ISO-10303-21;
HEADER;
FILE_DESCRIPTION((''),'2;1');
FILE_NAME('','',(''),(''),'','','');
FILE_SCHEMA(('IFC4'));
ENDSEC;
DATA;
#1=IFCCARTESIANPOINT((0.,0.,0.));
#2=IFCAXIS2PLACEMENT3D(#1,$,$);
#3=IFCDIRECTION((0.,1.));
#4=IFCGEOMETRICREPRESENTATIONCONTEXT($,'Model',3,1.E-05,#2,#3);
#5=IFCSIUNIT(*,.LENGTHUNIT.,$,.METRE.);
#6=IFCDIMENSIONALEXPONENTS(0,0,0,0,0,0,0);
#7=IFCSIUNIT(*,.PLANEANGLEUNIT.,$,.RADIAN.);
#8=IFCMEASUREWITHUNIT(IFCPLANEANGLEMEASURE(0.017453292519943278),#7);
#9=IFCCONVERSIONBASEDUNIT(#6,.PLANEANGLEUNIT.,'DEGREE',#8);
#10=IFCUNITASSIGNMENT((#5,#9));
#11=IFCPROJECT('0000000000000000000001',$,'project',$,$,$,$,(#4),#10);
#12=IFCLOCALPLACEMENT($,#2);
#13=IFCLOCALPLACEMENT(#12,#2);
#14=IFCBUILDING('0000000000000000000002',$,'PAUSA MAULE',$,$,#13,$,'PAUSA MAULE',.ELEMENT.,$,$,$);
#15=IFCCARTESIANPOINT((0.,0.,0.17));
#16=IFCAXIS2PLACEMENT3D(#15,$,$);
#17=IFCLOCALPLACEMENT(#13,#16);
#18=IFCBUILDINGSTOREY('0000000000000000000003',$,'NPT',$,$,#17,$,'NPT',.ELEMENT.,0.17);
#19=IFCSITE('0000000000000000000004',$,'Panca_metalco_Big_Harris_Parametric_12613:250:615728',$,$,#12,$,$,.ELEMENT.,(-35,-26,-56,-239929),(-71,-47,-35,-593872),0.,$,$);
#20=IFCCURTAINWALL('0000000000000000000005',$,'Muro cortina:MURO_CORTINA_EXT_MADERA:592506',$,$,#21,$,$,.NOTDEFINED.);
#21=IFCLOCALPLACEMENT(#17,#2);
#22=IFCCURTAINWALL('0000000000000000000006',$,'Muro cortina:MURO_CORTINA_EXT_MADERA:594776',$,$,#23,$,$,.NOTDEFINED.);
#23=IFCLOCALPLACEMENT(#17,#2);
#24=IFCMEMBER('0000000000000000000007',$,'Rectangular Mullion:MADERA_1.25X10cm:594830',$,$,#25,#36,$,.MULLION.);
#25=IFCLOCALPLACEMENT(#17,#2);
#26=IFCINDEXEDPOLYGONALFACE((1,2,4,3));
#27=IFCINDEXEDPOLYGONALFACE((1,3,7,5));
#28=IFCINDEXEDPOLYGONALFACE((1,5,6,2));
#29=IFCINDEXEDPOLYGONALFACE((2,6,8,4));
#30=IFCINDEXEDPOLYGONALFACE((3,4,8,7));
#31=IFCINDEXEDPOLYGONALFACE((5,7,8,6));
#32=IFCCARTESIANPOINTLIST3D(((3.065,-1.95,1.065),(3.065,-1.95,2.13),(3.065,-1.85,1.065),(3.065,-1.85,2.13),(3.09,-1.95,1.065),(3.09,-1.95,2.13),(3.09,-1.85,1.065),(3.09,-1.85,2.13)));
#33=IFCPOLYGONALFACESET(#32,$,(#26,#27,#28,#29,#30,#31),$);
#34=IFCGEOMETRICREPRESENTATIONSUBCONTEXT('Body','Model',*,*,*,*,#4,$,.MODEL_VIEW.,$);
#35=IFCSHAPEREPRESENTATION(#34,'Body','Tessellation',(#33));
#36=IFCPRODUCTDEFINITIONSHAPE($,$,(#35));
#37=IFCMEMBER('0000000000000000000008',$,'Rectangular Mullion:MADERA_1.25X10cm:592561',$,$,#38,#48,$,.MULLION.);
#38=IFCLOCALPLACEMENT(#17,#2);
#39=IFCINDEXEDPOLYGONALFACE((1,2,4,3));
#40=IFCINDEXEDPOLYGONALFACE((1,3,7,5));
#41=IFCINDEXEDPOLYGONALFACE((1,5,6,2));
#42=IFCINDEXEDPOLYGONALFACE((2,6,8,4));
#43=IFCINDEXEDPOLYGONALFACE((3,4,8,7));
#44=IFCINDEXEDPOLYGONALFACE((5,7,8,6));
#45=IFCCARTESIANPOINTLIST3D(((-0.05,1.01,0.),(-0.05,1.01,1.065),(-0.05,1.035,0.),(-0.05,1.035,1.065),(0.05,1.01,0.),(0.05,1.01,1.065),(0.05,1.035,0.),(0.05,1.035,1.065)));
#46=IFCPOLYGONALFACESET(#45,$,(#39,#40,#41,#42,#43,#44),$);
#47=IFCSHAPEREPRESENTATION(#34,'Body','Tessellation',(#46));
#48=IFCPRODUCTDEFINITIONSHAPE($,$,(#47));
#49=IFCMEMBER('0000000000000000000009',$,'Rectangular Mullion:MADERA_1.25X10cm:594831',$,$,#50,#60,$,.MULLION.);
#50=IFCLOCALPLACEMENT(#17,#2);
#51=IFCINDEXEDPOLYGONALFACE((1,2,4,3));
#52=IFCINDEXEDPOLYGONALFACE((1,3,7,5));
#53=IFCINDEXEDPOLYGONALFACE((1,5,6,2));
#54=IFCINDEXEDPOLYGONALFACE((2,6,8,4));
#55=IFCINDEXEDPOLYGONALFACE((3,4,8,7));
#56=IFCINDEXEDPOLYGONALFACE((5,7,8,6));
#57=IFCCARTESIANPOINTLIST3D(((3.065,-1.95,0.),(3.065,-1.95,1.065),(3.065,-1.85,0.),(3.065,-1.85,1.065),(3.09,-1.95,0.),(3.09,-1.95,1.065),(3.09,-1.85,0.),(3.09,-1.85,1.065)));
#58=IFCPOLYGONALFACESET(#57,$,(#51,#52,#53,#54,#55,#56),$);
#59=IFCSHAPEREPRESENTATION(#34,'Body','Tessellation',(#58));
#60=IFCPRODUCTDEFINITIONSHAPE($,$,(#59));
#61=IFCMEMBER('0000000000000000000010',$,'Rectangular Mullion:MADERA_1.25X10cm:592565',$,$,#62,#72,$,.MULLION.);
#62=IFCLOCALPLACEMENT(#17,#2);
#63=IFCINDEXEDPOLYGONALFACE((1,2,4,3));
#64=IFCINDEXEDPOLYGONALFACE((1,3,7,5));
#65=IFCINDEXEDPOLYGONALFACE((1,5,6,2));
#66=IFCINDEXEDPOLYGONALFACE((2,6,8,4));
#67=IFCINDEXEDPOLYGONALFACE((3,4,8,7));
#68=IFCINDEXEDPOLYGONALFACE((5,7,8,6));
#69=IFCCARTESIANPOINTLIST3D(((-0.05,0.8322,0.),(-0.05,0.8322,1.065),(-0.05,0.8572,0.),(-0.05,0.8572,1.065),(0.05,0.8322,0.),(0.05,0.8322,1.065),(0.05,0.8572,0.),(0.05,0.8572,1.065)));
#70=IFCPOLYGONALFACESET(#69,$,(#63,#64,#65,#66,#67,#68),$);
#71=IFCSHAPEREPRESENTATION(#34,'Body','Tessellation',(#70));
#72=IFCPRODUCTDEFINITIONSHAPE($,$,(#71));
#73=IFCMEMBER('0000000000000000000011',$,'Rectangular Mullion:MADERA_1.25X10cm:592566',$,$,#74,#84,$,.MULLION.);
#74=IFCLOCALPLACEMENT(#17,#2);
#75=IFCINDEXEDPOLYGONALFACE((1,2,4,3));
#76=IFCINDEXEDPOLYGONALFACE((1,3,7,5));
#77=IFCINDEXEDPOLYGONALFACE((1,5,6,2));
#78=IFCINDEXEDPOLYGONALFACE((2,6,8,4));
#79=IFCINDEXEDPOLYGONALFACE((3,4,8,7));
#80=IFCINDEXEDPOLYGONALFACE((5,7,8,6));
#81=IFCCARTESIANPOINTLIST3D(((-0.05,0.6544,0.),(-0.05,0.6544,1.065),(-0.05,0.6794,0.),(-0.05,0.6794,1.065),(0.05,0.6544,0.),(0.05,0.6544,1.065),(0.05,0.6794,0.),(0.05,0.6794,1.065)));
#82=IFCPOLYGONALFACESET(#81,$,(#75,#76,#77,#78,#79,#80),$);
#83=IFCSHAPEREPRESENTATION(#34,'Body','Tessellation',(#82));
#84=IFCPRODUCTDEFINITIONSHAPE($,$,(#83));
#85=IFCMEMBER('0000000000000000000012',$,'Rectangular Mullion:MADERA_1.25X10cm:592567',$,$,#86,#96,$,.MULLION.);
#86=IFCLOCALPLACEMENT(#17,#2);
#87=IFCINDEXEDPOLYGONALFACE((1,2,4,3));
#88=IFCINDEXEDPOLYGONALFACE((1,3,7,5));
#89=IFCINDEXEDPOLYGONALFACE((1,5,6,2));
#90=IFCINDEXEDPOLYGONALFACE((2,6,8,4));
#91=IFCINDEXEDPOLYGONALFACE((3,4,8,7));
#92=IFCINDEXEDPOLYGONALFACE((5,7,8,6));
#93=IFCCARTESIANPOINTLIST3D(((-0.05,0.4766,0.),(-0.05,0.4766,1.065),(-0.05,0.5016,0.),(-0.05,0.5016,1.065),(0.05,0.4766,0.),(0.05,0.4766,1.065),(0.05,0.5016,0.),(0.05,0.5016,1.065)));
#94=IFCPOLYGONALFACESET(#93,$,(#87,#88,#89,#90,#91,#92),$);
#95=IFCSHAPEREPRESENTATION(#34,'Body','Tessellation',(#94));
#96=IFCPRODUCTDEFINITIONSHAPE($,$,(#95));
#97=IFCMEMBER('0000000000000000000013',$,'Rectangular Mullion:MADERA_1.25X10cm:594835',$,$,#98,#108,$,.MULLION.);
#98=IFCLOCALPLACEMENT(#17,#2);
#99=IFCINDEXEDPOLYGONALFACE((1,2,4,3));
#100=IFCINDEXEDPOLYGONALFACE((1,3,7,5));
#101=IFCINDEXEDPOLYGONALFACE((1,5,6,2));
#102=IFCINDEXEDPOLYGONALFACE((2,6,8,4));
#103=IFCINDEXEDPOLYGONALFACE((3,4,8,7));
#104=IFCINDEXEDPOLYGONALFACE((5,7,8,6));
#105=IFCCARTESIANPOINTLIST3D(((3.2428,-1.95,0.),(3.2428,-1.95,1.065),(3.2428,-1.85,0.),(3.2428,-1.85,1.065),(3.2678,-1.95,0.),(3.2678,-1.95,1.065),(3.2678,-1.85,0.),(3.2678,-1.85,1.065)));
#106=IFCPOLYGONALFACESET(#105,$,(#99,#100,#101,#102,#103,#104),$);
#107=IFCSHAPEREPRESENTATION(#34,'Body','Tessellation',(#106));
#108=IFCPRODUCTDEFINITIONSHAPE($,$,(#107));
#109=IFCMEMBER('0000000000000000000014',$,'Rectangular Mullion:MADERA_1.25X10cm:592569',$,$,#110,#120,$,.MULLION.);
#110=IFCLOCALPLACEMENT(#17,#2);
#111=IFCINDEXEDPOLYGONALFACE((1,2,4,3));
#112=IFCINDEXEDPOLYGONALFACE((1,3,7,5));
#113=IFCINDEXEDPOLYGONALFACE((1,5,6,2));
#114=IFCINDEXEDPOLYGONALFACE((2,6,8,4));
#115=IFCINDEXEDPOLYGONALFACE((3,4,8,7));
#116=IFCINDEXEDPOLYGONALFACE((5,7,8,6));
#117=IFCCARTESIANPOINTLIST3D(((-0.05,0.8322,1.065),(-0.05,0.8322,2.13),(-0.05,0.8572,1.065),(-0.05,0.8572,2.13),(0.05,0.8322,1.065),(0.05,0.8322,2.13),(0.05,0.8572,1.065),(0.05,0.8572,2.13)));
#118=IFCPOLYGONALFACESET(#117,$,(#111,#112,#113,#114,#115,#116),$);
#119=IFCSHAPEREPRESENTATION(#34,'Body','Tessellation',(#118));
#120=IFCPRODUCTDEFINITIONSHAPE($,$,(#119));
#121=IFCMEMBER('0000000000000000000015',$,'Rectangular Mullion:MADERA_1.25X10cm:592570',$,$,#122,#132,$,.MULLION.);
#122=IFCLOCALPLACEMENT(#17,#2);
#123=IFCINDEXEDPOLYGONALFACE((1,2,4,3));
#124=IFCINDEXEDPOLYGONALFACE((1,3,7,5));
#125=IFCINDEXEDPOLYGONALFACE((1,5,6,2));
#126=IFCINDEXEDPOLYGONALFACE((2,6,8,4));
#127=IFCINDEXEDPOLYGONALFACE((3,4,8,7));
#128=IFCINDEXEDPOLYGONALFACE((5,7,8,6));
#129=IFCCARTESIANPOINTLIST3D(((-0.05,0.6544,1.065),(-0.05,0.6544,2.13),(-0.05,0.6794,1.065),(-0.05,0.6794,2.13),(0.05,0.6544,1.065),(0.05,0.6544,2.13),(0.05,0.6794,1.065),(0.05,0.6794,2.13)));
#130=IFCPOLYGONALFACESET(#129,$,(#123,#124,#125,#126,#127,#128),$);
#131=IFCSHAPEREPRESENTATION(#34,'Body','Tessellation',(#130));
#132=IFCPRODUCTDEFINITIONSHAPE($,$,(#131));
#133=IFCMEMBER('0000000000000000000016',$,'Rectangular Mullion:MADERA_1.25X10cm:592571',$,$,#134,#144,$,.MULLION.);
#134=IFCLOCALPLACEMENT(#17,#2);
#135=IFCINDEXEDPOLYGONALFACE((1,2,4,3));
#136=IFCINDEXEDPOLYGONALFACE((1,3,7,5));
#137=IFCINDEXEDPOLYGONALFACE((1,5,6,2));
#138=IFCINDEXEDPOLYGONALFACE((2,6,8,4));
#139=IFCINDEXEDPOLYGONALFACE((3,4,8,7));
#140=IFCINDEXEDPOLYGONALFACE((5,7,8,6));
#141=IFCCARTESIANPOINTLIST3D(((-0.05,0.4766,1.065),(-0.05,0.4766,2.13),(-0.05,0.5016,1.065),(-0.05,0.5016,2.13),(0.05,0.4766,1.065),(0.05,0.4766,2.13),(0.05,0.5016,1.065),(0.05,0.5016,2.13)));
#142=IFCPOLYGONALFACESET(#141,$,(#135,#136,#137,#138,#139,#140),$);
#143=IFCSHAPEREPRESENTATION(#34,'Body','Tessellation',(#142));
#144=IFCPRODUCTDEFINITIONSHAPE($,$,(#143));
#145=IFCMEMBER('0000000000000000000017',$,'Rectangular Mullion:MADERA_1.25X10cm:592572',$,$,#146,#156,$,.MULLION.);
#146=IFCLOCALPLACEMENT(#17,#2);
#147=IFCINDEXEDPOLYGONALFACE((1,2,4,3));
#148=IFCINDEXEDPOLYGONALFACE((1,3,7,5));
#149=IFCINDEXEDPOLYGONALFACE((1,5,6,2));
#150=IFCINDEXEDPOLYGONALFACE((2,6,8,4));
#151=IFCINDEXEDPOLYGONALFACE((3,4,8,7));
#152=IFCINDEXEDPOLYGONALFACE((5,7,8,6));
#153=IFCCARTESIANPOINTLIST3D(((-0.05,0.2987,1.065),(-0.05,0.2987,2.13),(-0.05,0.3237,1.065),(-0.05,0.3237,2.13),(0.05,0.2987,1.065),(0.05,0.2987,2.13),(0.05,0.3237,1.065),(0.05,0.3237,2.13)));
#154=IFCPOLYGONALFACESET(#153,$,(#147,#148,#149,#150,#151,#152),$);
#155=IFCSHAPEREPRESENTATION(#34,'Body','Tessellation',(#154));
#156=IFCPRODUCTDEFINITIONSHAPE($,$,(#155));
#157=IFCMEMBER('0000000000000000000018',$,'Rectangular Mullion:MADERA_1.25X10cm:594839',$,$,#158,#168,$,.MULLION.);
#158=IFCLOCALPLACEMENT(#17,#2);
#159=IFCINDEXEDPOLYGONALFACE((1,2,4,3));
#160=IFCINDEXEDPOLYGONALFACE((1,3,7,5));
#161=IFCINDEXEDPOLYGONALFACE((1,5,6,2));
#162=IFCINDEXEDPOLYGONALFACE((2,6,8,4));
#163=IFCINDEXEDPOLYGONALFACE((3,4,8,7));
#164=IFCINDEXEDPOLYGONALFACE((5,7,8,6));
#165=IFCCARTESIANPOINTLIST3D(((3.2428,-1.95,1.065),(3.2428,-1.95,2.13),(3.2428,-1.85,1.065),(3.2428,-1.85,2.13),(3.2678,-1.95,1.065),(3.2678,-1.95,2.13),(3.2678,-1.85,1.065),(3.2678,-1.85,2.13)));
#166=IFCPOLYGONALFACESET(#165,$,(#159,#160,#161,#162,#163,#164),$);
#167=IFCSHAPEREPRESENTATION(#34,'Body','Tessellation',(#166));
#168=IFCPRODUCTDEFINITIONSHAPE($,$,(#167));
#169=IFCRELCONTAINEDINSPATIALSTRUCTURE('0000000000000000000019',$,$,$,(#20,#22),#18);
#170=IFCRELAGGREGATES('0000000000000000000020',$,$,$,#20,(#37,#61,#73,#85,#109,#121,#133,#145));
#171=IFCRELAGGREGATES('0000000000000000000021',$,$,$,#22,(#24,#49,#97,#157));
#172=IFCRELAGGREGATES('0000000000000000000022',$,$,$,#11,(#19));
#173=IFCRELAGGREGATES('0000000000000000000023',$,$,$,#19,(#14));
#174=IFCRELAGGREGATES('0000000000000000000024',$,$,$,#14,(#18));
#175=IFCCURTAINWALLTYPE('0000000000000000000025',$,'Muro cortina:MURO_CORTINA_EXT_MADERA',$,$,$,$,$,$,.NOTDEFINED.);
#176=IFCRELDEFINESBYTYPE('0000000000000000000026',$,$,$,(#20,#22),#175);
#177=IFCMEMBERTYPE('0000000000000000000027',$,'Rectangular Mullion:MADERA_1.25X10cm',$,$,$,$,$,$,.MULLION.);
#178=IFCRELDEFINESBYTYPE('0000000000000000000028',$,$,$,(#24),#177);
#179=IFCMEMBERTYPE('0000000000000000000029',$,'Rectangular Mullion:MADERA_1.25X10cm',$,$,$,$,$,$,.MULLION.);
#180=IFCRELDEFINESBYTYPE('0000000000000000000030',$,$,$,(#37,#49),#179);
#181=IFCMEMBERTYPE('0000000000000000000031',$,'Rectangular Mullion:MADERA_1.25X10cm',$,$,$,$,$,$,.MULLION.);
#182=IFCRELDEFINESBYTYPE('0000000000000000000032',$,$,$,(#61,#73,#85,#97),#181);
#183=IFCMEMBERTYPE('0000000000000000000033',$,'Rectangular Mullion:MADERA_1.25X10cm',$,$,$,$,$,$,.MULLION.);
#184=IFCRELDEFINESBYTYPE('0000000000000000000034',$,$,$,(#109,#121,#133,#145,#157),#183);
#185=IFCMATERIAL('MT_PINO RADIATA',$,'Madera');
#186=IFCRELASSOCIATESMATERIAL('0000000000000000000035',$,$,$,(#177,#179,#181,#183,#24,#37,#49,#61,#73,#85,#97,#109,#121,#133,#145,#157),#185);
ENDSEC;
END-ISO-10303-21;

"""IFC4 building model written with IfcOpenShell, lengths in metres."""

from ifc_helpers import new_model, entity, si_unit, converted_unit, direction, frame, frame_2d, origin, place, context, subcontext, project, spatial, rectangle, extrude, source, transform, mapped, material, material_profile, profile_set, profile_usage, type_object, type_shapes, element, aggregate, save


model = new_model("IFC4")

# Units and contexts
model_context = context("Model", 3, precision=1e-05, world=origin(), true_north=direction((0.0, 1.0)))
body_context = subcontext(model_context, "Body", "Model", "MODEL_VIEW")
ifc_project = project(units=[si_unit("LENGTHUNIT", "METRE"), converted_unit("PLANEANGLEUNIT", "DEGREE", entity("IfcPlaneAngleMeasure", 0.017453292519943278), si_unit("PLANEANGLEUNIT", "RADIAN"), dimensions=[0, 0, 0, 0, 0, 0, 0])], contexts=[model_context])

# Site, building, storey
site_placement = place(None, origin())
site = spatial("IfcSite", under=ifc_project, at=site_placement, Name="Panca_metalco_Big_Harris_Parametric_12613:250:615728", CompositionType="ELEMENT", RefLatitude=(-35, -26, -56, -239929), RefLongitude=(-71, -47, -35, -593872), RefElevation=0.0)
building_placement = place(site_placement, origin())
building = spatial("IfcBuilding", under=site, at=building_placement, Name="PAUSA MAULE", LongName="PAUSA MAULE", CompositionType="ELEMENT")
storey_placement = place(building_placement, frame((0.0, 0.0, 0.17)))
storey = spatial("IfcBuildingStorey", under=building, at=storey_placement, Name="NPT", LongName="NPT", CompositionType="ELEMENT", Elevation=0.17)

# Curtain walls
curtain_wall_type = type_object("IfcCurtainWallType", Name="Muro cortina:MURO_CORTINA_EXT_MADERA", PredefinedType="NOTDEFINED")
curtain_wall_1_placement = place(storey_placement, frame((0.0, 0.0, -0.17)))
curtain_wall_1 = element("IfcCurtainWall", 1, at=curtain_wall_1_placement, inside=storey, type_object=curtain_wall_type, Name="Muro cortina:MURO_CORTINA_EXT_MADERA:592506", PredefinedType="NOTDEFINED")
ifc_material = material(Name="MT_PINO RADIATA", Category="Madera")
ifc_material_profile = material_profile(ifc_material, rectangle(XDim=0.025, YDim=0.1, at=frame_2d((0.0, 0.0), x_axis=(1.0, 0.0))), Name="MADERA_1.25X10cm")
ifc_profile_set = profile_set([ifc_material_profile], Name="MADERA_1.25X10cm")
ifc_profile_usage = profile_usage(ifc_profile_set)
curtain_wall_2_placement = place(storey_placement, frame((0.0, 0.0, -0.17)))
curtain_wall_2 = element("IfcCurtainWall", 2, at=curtain_wall_2_placement, inside=storey, type_object=curtain_wall_type, Name="Muro cortina:MURO_CORTINA_EXT_MADERA:594776", PredefinedType="NOTDEFINED")

# Members
member_type_1 = type_object("IfcMemberType", Name="Rectangular Mullion:MADERA_1.25X10cm", PredefinedType="MULLION", material=ifc_profile_set)
shared_shape_1 = source(origin(), body_context, "Body", "SweptSolid", [
    extrude(rectangle(XDim=0.025, YDim=0.1, at=frame_2d((0.0, 0.0), x_axis=(1.0, 0.0))), frame((-0.0125, 0.0, -1.065), z_axis=(0.0, 0.0, 1.0), x_axis=(-1.0, 0.0, 0.0)), (0.0, 0.0, 1.0), 1.065),
])
type_shapes(member_type_1, [shared_shape_1])
member_1_placement = place(curtain_wall_2_placement, frame((3.065, -1.9, 2.3), z_axis=(0.0, 0.0, 1.0), x_axis=(-1.0, 0.0, 0.0)))
member_1 = element("IfcMember", 3, at=member_1_placement, type_object=member_type_1, material=ifc_profile_usage, Name="Rectangular Mullion:MADERA_1.25X10cm:594830", PredefinedType="MULLION", context=body_context, shape_type="MappedRepresentation", body=[
    mapped(shared_shape_1, transform((0.0, 0.0, 0.0), scale=1.0)),
])
member_type_2 = type_object("IfcMemberType", Name="Rectangular Mullion:MADERA_1.25X10cm", PredefinedType="MULLION", material=ifc_profile_set)
shared_shape_2 = source(origin(), body_context, "Body", "SweptSolid", [
    extrude(rectangle(XDim=0.025, YDim=0.1, at=frame_2d((0.0, 0.0), x_axis=(1.0, 0.0))), frame((-0.0125, 0.0, -1.065), z_axis=(0.0, 0.0, 1.0), x_axis=(-1.0, 0.0, 0.0)), (0.0, 0.0, 1.0), 1.065),
])
type_shapes(member_type_2, [shared_shape_2])
member_2_placement = place(curtain_wall_1_placement, frame((0.0, 1.035, 1.235), z_axis=(0.0, 0.0, 1.0), x_axis=(0.0, 1.0, 0.0)))
member_2 = element("IfcMember", 4, at=member_2_placement, type_object=member_type_2, material=ifc_profile_usage, Name="Rectangular Mullion:MADERA_1.25X10cm:592561", PredefinedType="MULLION", context=body_context, shape_type="MappedRepresentation", body=[
    mapped(shared_shape_2, transform((0.0, 0.0, 0.0), scale=1.0)),
])
member_3_placement = place(curtain_wall_2_placement, frame((3.065, -1.9, 1.235), z_axis=(0.0, 0.0, 1.0), x_axis=(-1.0, 0.0, 0.0)))
member_3 = element("IfcMember", 5, at=member_3_placement, type_object=member_type_2, material=ifc_profile_usage, Name="Rectangular Mullion:MADERA_1.25X10cm:594831", PredefinedType="MULLION", context=body_context, shape_type="MappedRepresentation", body=[
    mapped(shared_shape_2, transform((0.0, 0.0, 0.0), scale=1.0)),
])
member_type_3 = type_object("IfcMemberType", Name="Rectangular Mullion:MADERA_1.25X10cm", PredefinedType="MULLION", material=ifc_profile_set)
shared_shape_3 = source(origin(), body_context, "Body", "SweptSolid", [
    extrude(rectangle(XDim=0.025, YDim=0.1, at=frame_2d((0.0, 0.0), x_axis=(1.0, 0.0))), frame((0.0, 0.0, -1.065), z_axis=(0.0, 0.0, 1.0), x_axis=(-1.0, 0.0, 0.0)), (0.0, 0.0, 1.0), 1.065),
])
type_shapes(member_type_3, [shared_shape_3])
member_4_placement = place(curtain_wall_1_placement, frame((0.0, 0.8447, 0.17), z_axis=(0.0, 0.0, -1.0), x_axis=(0.0, -1.0, 0.0)))
member_4 = element("IfcMember", 6, at=member_4_placement, type_object=member_type_3, material=ifc_profile_usage, Name="Rectangular Mullion:MADERA_1.25X10cm:592565", PredefinedType="MULLION", context=body_context, shape_type="MappedRepresentation", body=[
    mapped(shared_shape_3, transform((0.0, 0.0, 0.0), scale=1.0)),
])
member_5_placement = place(curtain_wall_1_placement, frame((0.0, 0.6669, 0.17), z_axis=(0.0, 0.0, -1.0), x_axis=(0.0, -1.0, 0.0)))
member_5 = element("IfcMember", 7, at=member_5_placement, type_object=member_type_3, material=ifc_profile_usage, Name="Rectangular Mullion:MADERA_1.25X10cm:592566", PredefinedType="MULLION", context=body_context, shape_type="MappedRepresentation", body=[
    mapped(shared_shape_3, transform((0.0, 0.0, 0.0), scale=1.0)),
])
member_6_placement = place(curtain_wall_1_placement, frame((0.0, 0.4891, 0.17), z_axis=(0.0, 0.0, -1.0), x_axis=(0.0, -1.0, 0.0)))
member_6 = element("IfcMember", 8, at=member_6_placement, type_object=member_type_3, material=ifc_profile_usage, Name="Rectangular Mullion:MADERA_1.25X10cm:592567", PredefinedType="MULLION", context=body_context, shape_type="MappedRepresentation", body=[
    mapped(shared_shape_3, transform((0.0, 0.0, 0.0), scale=1.0)),
])
member_7_placement = place(curtain_wall_2_placement, frame((3.2553, -1.9, 0.17), z_axis=(0.0, 0.0, -1.0), x_axis=(1.0, 0.0, 0.0)))
member_7 = element("IfcMember", 9, at=member_7_placement, type_object=member_type_3, material=ifc_profile_usage, Name="Rectangular Mullion:MADERA_1.25X10cm:594835", PredefinedType="MULLION", context=body_context, shape_type="MappedRepresentation", body=[
    mapped(shared_shape_3, transform((0.0, 0.0, 0.0), scale=1.0)),
])
member_type_4 = type_object("IfcMemberType", Name="Rectangular Mullion:MADERA_1.25X10cm", PredefinedType="MULLION", material=ifc_profile_set)
shared_shape_4 = source(origin(), body_context, "Body", "SweptSolid", [
    extrude(rectangle(XDim=0.025, YDim=0.1, at=frame_2d((0.0, 0.0), x_axis=(1.0, 0.0))), frame((0.0, 0.0, -1.065), z_axis=(0.0, 0.0, 1.0), x_axis=(-1.0, 0.0, 0.0)), (0.0, 0.0, 1.0), 1.065),
])
type_shapes(member_type_4, [shared_shape_4])
member_8_placement = place(curtain_wall_1_placement, frame((0.0, 0.8447, 1.235), z_axis=(0.0, 0.0, -1.0), x_axis=(0.0, -1.0, 0.0)))
member_8 = element("IfcMember", 10, at=member_8_placement, type_object=member_type_4, material=ifc_profile_usage, Name="Rectangular Mullion:MADERA_1.25X10cm:592569", PredefinedType="MULLION", context=body_context, shape_type="MappedRepresentation", body=[
    mapped(shared_shape_4, transform((0.0, 0.0, 0.0), scale=1.0)),
])
member_9_placement = place(curtain_wall_1_placement, frame((0.0, 0.6669, 1.235), z_axis=(0.0, 0.0, -1.0), x_axis=(0.0, -1.0, 0.0)))
member_9 = element("IfcMember", 11, at=member_9_placement, type_object=member_type_4, material=ifc_profile_usage, Name="Rectangular Mullion:MADERA_1.25X10cm:592570", PredefinedType="MULLION", context=body_context, shape_type="MappedRepresentation", body=[
    mapped(shared_shape_4, transform((0.0, 0.0, 0.0), scale=1.0)),
])
member_10_placement = place(curtain_wall_1_placement, frame((0.0, 0.4891, 1.235), z_axis=(0.0, 0.0, -1.0), x_axis=(0.0, -1.0, 0.0)))
member_10 = element("IfcMember", 12, at=member_10_placement, type_object=member_type_4, material=ifc_profile_usage, Name="Rectangular Mullion:MADERA_1.25X10cm:592571", PredefinedType="MULLION", context=body_context, shape_type="MappedRepresentation", body=[
    mapped(shared_shape_4, transform((0.0, 0.0, 0.0), scale=1.0)),
])
member_11_placement = place(curtain_wall_1_placement, frame((0.0, 0.3112, 1.235), z_axis=(0.0, 0.0, -1.0), x_axis=(0.0, -1.0, 0.0)))
member_11 = element("IfcMember", 13, at=member_11_placement, type_object=member_type_4, material=ifc_profile_usage, Name="Rectangular Mullion:MADERA_1.25X10cm:592572", PredefinedType="MULLION", context=body_context, shape_type="MappedRepresentation", body=[
    mapped(shared_shape_4, transform((0.0, 0.0, 0.0), scale=1.0)),
])
aggregate(curtain_wall_1, [member_2, member_4, member_5, member_6, member_8, member_9, member_10, member_11])
member_12_placement = place(curtain_wall_2_placement, frame((3.2553, -1.9, 1.235), z_axis=(0.0, 0.0, -1.0), x_axis=(1.0, 0.0, 0.0)))
member_12 = element("IfcMember", 14, at=member_12_placement, type_object=member_type_4, material=ifc_profile_usage, Name="Rectangular Mullion:MADERA_1.25X10cm:594839", PredefinedType="MULLION", context=body_context, shape_type="MappedRepresentation", body=[
    mapped(shared_shape_4, transform((0.0, 0.0, 0.0), scale=1.0)),
])
aggregate(curtain_wall_2, [member_1, member_3, member_7, member_12])

save(model, "model.ifc")
